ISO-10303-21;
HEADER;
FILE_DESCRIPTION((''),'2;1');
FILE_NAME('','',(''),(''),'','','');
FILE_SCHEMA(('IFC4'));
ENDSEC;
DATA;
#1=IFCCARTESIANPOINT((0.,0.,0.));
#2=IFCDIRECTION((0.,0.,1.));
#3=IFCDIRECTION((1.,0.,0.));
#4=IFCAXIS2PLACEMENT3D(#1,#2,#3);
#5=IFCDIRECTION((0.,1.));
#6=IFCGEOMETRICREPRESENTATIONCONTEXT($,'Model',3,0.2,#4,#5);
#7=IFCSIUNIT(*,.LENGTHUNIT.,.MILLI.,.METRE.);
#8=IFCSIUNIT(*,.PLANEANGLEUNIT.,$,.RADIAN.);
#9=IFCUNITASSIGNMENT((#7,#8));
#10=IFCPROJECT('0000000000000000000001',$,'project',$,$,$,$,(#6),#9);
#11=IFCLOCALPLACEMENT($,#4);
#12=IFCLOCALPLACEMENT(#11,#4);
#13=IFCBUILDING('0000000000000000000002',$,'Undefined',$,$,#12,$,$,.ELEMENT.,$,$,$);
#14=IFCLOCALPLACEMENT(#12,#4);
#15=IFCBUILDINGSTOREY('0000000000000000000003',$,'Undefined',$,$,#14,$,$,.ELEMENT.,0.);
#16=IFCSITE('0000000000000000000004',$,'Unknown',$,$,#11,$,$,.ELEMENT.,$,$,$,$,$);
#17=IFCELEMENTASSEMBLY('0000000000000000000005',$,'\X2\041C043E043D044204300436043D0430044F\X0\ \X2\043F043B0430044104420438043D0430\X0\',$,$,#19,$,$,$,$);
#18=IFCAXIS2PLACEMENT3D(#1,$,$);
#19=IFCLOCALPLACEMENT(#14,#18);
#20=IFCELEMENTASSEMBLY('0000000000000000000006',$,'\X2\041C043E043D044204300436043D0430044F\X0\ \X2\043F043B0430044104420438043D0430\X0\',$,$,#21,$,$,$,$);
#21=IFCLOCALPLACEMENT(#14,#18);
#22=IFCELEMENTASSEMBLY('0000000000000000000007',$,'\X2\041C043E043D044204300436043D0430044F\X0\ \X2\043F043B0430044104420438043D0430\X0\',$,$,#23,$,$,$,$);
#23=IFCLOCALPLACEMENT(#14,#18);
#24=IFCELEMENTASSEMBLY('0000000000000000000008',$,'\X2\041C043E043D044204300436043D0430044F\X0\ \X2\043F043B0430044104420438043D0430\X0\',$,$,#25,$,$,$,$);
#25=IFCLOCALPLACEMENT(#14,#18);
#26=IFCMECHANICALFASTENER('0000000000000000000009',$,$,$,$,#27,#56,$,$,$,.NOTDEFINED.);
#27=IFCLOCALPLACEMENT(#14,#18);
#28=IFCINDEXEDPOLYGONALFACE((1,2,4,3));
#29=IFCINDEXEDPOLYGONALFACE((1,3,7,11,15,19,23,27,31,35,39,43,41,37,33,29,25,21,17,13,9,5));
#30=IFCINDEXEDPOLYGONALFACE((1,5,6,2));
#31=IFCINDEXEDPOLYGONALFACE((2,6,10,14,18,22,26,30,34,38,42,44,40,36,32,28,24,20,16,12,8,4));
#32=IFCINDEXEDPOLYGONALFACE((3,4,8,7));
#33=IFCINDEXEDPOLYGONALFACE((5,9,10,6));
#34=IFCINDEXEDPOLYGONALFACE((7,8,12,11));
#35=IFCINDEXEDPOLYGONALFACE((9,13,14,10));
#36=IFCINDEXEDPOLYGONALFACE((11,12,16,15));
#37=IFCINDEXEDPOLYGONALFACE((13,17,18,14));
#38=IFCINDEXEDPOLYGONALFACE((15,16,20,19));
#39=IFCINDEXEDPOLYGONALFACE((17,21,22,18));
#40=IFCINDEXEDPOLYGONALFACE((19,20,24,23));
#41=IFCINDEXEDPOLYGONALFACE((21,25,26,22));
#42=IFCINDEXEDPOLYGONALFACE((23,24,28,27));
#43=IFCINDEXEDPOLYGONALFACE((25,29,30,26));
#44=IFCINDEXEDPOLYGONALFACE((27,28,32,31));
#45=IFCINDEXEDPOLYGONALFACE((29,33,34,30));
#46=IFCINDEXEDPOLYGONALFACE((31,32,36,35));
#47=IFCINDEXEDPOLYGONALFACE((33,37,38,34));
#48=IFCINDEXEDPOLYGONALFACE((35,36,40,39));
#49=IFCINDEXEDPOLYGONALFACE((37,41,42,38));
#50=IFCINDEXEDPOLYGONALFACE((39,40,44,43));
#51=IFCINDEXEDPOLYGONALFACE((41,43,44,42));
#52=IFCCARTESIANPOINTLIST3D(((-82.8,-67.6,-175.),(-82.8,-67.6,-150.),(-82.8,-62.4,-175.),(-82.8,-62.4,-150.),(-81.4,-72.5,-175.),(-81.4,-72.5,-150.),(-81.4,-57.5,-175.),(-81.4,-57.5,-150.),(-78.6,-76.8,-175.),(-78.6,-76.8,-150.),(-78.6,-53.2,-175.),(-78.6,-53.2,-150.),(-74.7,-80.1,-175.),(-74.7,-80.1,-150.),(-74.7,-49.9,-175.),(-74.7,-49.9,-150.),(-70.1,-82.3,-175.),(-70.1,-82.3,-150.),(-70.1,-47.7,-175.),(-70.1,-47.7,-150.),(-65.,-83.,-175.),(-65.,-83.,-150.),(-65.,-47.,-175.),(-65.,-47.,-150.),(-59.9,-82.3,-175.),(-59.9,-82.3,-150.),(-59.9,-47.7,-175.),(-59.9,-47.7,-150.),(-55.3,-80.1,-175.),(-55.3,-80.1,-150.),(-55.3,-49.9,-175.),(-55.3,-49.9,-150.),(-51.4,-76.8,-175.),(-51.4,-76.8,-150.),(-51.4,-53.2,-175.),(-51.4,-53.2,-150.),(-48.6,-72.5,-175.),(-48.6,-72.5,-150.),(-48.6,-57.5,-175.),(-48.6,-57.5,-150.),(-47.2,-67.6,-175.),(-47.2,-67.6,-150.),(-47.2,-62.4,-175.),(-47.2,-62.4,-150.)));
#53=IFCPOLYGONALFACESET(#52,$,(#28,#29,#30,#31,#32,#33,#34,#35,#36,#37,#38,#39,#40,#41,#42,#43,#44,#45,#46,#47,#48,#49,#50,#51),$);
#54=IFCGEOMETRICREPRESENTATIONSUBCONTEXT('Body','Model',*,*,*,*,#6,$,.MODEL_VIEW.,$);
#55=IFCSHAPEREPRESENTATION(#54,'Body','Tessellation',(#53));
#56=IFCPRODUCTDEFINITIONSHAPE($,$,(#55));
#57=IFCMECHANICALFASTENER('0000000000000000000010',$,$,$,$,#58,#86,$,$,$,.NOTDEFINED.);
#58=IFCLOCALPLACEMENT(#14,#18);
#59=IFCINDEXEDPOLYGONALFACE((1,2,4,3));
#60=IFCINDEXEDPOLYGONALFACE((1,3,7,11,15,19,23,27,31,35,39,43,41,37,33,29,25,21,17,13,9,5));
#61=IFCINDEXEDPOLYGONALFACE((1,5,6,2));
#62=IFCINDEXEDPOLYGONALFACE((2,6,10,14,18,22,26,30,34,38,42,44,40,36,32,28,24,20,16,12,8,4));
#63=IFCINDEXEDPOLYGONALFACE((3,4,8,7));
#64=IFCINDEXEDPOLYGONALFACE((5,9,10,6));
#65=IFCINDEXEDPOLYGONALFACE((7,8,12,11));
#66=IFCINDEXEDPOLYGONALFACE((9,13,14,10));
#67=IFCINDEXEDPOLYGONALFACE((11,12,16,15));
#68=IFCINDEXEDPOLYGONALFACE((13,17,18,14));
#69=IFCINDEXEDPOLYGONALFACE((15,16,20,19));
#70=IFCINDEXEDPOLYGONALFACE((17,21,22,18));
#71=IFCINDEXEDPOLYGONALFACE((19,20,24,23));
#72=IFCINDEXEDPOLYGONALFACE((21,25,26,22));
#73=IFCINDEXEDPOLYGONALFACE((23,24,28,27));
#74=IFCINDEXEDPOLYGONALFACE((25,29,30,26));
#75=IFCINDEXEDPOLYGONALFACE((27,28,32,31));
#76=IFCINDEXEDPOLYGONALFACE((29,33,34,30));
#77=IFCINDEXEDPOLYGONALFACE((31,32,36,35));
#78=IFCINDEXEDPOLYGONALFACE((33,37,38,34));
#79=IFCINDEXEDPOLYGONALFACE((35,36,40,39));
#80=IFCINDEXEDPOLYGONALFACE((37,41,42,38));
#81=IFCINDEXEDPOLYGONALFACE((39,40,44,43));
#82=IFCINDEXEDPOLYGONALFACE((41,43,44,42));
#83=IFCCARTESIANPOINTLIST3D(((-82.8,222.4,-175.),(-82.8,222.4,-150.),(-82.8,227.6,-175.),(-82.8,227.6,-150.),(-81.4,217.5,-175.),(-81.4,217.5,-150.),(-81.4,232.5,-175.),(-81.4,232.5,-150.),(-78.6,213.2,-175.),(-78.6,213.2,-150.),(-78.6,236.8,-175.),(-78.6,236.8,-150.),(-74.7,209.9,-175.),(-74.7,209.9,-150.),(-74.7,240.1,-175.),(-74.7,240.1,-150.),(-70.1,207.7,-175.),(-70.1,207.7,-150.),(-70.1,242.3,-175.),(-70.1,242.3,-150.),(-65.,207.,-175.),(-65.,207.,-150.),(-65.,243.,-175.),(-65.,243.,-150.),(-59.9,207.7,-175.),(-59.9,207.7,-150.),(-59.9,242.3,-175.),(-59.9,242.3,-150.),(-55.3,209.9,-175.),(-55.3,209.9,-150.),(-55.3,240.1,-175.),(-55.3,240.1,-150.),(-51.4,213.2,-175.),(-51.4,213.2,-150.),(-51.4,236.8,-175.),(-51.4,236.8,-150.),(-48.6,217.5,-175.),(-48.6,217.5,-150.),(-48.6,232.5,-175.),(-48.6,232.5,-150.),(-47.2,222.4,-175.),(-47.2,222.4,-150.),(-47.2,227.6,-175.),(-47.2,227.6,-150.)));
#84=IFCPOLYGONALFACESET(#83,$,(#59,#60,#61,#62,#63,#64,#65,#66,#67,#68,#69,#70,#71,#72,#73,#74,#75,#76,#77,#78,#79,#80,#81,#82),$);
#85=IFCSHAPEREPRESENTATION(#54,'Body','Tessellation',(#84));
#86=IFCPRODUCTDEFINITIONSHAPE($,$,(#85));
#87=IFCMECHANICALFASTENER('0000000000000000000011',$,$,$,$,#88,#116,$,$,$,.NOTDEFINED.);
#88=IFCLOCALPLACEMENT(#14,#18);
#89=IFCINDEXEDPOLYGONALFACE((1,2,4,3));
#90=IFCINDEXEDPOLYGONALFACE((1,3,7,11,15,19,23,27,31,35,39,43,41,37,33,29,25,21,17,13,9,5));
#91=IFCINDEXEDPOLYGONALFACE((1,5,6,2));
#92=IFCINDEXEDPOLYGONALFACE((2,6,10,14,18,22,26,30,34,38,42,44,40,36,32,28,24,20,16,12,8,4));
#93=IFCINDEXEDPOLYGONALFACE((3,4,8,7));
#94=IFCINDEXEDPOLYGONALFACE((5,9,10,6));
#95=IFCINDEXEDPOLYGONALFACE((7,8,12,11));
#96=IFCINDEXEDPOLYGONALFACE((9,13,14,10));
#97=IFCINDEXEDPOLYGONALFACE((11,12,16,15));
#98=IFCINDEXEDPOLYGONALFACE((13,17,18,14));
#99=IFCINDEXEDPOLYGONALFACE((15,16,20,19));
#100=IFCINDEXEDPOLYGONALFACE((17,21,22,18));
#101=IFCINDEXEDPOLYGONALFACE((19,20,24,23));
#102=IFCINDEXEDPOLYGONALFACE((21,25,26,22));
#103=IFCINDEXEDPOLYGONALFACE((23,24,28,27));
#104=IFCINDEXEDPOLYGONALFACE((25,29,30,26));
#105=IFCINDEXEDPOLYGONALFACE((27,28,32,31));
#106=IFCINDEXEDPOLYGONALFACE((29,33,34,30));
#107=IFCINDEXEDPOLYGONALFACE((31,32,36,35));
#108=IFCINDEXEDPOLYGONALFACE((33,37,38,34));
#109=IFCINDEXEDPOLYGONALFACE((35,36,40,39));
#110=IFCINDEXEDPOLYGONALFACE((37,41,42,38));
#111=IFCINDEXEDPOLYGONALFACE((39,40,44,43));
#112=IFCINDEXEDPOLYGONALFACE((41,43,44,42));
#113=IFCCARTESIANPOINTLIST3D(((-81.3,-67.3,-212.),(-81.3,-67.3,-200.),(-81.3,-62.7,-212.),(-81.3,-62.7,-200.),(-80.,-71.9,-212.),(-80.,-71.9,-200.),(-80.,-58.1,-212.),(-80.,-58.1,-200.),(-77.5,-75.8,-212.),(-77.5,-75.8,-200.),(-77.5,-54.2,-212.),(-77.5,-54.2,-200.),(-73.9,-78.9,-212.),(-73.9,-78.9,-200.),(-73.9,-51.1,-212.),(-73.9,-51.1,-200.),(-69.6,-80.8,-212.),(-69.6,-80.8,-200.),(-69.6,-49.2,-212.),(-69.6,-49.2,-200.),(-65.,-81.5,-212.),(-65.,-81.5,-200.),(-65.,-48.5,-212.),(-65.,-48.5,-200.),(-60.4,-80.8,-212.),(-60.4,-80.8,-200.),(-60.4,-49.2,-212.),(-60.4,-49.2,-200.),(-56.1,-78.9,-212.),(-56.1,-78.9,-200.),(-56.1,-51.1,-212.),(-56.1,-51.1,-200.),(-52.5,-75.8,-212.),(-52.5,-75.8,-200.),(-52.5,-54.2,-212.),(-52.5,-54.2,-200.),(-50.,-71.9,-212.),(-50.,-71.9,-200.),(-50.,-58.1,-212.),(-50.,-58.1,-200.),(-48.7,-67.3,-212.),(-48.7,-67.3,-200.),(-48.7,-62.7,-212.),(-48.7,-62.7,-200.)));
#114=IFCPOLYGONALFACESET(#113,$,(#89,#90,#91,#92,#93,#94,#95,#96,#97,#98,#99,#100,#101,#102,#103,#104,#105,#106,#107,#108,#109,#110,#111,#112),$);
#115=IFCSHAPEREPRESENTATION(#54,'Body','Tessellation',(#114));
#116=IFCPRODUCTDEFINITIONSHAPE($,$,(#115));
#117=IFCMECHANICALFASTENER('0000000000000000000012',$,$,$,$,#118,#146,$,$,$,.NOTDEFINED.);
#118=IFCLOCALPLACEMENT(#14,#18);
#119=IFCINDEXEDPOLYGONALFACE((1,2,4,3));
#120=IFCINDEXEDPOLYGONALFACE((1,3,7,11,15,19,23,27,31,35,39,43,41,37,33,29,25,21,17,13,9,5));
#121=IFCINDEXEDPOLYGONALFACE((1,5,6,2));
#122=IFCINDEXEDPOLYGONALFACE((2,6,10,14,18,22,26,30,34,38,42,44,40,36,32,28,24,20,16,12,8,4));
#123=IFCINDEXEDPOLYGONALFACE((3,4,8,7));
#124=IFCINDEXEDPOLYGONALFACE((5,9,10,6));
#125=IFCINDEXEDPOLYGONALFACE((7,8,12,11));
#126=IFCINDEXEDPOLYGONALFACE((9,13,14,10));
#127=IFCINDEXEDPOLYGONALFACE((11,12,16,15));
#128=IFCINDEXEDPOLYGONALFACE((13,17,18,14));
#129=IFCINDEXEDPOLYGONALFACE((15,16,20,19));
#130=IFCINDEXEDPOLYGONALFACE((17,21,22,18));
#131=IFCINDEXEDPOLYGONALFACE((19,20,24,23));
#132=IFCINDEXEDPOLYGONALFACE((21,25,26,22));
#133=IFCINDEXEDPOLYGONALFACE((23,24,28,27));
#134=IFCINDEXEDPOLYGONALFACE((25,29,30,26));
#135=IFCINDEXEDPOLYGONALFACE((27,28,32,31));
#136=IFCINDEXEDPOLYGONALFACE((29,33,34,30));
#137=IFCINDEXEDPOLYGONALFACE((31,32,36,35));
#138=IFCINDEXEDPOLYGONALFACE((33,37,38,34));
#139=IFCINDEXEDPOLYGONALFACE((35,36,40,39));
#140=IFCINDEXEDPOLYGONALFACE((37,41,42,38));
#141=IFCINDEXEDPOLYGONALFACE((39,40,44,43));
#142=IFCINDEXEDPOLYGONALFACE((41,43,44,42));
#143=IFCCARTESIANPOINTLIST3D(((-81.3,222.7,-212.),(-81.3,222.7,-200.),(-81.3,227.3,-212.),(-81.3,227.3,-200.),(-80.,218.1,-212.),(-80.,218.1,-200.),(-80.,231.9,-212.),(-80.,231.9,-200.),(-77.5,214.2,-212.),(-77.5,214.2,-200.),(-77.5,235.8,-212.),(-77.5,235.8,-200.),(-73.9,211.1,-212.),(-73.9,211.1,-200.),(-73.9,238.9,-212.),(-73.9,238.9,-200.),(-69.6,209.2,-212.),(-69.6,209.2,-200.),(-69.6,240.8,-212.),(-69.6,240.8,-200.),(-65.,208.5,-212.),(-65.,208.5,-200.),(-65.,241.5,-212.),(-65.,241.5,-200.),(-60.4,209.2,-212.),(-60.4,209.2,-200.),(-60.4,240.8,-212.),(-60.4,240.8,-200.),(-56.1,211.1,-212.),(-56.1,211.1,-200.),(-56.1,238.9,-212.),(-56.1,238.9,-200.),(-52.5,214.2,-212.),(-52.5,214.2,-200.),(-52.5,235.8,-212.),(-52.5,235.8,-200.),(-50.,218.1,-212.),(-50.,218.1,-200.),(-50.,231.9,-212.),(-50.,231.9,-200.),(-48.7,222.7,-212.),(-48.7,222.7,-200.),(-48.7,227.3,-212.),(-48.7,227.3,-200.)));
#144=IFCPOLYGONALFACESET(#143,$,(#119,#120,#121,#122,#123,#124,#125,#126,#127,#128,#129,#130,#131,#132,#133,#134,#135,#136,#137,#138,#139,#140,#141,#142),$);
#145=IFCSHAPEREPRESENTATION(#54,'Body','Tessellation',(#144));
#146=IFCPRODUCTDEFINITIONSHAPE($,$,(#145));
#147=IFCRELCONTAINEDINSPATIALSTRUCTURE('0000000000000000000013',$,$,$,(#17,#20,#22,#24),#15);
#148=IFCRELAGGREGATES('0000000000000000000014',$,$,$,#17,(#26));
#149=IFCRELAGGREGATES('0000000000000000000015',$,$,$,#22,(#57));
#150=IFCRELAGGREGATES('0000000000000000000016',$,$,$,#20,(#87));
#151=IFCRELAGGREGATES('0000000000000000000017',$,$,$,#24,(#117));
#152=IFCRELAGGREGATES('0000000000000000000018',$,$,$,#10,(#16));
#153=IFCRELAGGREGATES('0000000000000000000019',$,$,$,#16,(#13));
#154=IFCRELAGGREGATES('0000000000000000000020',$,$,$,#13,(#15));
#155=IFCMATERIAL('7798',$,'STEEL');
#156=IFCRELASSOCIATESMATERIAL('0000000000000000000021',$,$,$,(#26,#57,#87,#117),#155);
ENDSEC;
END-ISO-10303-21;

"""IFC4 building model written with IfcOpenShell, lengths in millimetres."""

from ifc_helpers import new_model, si_unit, direction, frame, origin_with_axes, place, context, subcontext, project, spatial, arc, indexed_curve, outline, extrude, source, transform, mapped, material, element, aggregate, save


model = new_model("IFC4")

# Units and contexts
model_context = context("Model", 3, precision=0.2, world=origin_with_axes(), true_north=direction((0.0, 1.0)))
body_context = subcontext(model_context, "Body", "Model", "MODEL_VIEW")
ifc_project = project(units=[si_unit("LENGTHUNIT", "METRE", prefix="MILLI"), si_unit("PLANEANGLEUNIT", "RADIAN")], contexts=[model_context])

# Site, building, storey
site_placement = place(None, origin_with_axes())
site = spatial("IfcSite", under=ifc_project, at=site_placement, Name="Unknown", CompositionType="ELEMENT")
building_placement = place(site_placement, origin_with_axes())
building = spatial("IfcBuilding", under=site, at=building_placement, Name="Undefined", CompositionType="ELEMENT")
storey_placement = place(building_placement, origin_with_axes())
storey = spatial("IfcBuildingStorey", under=building, at=storey_placement, Name="Undefined", CompositionType="ELEMENT", Elevation=0.0)

# Element assemblies
assembly_1_placement = place(storey_placement, frame((-115.0, -65.0, -162.5), z_axis=(0.0, 0.0, -1.0), x_axis=(1.0, 0.0, 0.0)))
assembly_1 = element("IfcElementAssembly", 1, at=assembly_1_placement, inside=storey, Name="Монтажная пластина")
assembly_2_placement = place(storey_placement, frame((-115.0, -65.0, -206.0), z_axis=(0.0, 0.0, -1.0), x_axis=(1.0, 0.0, 0.0)))
assembly_2 = element("IfcElementAssembly", 2, at=assembly_2_placement, inside=storey, Name="Монтажная пластина")
assembly_3_placement = place(storey_placement, frame((-115.0, 225.0, -162.5), z_axis=(0.0, 0.0, -1.0), x_axis=(1.0, 0.0, 0.0)))
assembly_3 = element("IfcElementAssembly", 3, at=assembly_3_placement, inside=storey, Name="Монтажная пластина")
assembly_4_placement = place(storey_placement, frame((-115.0, 225.0, -206.0), z_axis=(0.0, 0.0, -1.0), x_axis=(1.0, 0.0, 0.0)))
assembly_4 = element("IfcElementAssembly", 4, at=assembly_4_placement, inside=storey, Name="Монтажная пластина")

# Mechanical fasteners
ifc_material_1 = material(Name="7798", Category="STEEL")
shared_shape_1 = source(origin_with_axes(), body_context, "Body", "SweptSolid", [
    extrude(outline(indexed_curve([(18.0, 0.0), (0.0, 18.0), (-18.0, 0.0), (0.0, -18.0)], segments=[arc(1, 2, 3), arc(3, 4, 1)])), frame((0.0, 0.0, 0.0), z_axis=(0.0, 0.0, -1.0), x_axis=(0.0, 1.0, 0.0)), (0.0, 0.0, 1.0), 25.0),
])
mechanical_fastener_1_placement = place(assembly_1_placement, frame((50.0, 0.0, 12.5), z_axis=(0.0, 0.0, 1.0), x_axis=(1.0, 0.0, 0.0)))
mechanical_fastener_1 = element("IfcMechanicalFastener", 5, at=mechanical_fastener_1_placement, material=ifc_material_1, PredefinedType="NOTDEFINED", context=body_context, shape_type="MappedRepresentation", body=[
    mapped(shared_shape_1, transform((0.0, 0.0, 0.0))),
])
aggregate(assembly_1, [mechanical_fastener_1])
mechanical_fastener_2_placement = place(assembly_3_placement, frame((50.0, 0.0, 12.5), z_axis=(0.0, 0.0, 1.0), x_axis=(1.0, 0.0, 0.0)))
mechanical_fastener_2 = element("IfcMechanicalFastener", 6, at=mechanical_fastener_2_placement, material=ifc_material_1, PredefinedType="NOTDEFINED", context=body_context, shape_type="MappedRepresentation", body=[
    mapped(shared_shape_1, transform((0.0, 0.0, 0.0))),
])
aggregate(assembly_3, [mechanical_fastener_2])
shared_shape_2 = source(origin_with_axes(), body_context, "Body", "SweptSolid", [
    extrude(outline(indexed_curve([(16.5, 0.0), (0.0, 16.5), (-16.5, 0.0), (0.0, -16.5)], segments=[arc(1, 2, 3), arc(3, 4, 1)])), frame((0.0, 0.0, 12.0), z_axis=(0.0, 0.0, -1.0), x_axis=(0.0, 1.0, 0.0)), (0.0, 0.0, 1.0), 12.0),
])
mechanical_fastener_3_placement = place(assembly_2_placement, frame((50.0, 0.0, -6.0), z_axis=(0.0, 0.0, 1.0), x_axis=(1.0, 0.0, 0.0)))
mechanical_fastener_3 = element("IfcMechanicalFastener", 7, at=mechanical_fastener_3_placement, material=ifc_material_1, PredefinedType="NOTDEFINED", context=body_context, shape_type="MappedRepresentation", body=[
    mapped(shared_shape_2, transform((0.0, 0.0, 0.0))),
])
aggregate(assembly_2, [mechanical_fastener_3])
mechanical_fastener_4_placement = place(assembly_4_placement, frame((50.0, 0.0, -6.0), z_axis=(0.0, 0.0, 1.0), x_axis=(1.0, 0.0, 0.0)))
mechanical_fastener_4 = element("IfcMechanicalFastener", 8, at=mechanical_fastener_4_placement, material=ifc_material_1, PredefinedType="NOTDEFINED", context=body_context, shape_type="MappedRepresentation", body=[
    mapped(shared_shape_2, transform((0.0, 0.0, 0.0))),
])
aggregate(assembly_4, [mechanical_fastener_4])

save(model, "model.ifc")
